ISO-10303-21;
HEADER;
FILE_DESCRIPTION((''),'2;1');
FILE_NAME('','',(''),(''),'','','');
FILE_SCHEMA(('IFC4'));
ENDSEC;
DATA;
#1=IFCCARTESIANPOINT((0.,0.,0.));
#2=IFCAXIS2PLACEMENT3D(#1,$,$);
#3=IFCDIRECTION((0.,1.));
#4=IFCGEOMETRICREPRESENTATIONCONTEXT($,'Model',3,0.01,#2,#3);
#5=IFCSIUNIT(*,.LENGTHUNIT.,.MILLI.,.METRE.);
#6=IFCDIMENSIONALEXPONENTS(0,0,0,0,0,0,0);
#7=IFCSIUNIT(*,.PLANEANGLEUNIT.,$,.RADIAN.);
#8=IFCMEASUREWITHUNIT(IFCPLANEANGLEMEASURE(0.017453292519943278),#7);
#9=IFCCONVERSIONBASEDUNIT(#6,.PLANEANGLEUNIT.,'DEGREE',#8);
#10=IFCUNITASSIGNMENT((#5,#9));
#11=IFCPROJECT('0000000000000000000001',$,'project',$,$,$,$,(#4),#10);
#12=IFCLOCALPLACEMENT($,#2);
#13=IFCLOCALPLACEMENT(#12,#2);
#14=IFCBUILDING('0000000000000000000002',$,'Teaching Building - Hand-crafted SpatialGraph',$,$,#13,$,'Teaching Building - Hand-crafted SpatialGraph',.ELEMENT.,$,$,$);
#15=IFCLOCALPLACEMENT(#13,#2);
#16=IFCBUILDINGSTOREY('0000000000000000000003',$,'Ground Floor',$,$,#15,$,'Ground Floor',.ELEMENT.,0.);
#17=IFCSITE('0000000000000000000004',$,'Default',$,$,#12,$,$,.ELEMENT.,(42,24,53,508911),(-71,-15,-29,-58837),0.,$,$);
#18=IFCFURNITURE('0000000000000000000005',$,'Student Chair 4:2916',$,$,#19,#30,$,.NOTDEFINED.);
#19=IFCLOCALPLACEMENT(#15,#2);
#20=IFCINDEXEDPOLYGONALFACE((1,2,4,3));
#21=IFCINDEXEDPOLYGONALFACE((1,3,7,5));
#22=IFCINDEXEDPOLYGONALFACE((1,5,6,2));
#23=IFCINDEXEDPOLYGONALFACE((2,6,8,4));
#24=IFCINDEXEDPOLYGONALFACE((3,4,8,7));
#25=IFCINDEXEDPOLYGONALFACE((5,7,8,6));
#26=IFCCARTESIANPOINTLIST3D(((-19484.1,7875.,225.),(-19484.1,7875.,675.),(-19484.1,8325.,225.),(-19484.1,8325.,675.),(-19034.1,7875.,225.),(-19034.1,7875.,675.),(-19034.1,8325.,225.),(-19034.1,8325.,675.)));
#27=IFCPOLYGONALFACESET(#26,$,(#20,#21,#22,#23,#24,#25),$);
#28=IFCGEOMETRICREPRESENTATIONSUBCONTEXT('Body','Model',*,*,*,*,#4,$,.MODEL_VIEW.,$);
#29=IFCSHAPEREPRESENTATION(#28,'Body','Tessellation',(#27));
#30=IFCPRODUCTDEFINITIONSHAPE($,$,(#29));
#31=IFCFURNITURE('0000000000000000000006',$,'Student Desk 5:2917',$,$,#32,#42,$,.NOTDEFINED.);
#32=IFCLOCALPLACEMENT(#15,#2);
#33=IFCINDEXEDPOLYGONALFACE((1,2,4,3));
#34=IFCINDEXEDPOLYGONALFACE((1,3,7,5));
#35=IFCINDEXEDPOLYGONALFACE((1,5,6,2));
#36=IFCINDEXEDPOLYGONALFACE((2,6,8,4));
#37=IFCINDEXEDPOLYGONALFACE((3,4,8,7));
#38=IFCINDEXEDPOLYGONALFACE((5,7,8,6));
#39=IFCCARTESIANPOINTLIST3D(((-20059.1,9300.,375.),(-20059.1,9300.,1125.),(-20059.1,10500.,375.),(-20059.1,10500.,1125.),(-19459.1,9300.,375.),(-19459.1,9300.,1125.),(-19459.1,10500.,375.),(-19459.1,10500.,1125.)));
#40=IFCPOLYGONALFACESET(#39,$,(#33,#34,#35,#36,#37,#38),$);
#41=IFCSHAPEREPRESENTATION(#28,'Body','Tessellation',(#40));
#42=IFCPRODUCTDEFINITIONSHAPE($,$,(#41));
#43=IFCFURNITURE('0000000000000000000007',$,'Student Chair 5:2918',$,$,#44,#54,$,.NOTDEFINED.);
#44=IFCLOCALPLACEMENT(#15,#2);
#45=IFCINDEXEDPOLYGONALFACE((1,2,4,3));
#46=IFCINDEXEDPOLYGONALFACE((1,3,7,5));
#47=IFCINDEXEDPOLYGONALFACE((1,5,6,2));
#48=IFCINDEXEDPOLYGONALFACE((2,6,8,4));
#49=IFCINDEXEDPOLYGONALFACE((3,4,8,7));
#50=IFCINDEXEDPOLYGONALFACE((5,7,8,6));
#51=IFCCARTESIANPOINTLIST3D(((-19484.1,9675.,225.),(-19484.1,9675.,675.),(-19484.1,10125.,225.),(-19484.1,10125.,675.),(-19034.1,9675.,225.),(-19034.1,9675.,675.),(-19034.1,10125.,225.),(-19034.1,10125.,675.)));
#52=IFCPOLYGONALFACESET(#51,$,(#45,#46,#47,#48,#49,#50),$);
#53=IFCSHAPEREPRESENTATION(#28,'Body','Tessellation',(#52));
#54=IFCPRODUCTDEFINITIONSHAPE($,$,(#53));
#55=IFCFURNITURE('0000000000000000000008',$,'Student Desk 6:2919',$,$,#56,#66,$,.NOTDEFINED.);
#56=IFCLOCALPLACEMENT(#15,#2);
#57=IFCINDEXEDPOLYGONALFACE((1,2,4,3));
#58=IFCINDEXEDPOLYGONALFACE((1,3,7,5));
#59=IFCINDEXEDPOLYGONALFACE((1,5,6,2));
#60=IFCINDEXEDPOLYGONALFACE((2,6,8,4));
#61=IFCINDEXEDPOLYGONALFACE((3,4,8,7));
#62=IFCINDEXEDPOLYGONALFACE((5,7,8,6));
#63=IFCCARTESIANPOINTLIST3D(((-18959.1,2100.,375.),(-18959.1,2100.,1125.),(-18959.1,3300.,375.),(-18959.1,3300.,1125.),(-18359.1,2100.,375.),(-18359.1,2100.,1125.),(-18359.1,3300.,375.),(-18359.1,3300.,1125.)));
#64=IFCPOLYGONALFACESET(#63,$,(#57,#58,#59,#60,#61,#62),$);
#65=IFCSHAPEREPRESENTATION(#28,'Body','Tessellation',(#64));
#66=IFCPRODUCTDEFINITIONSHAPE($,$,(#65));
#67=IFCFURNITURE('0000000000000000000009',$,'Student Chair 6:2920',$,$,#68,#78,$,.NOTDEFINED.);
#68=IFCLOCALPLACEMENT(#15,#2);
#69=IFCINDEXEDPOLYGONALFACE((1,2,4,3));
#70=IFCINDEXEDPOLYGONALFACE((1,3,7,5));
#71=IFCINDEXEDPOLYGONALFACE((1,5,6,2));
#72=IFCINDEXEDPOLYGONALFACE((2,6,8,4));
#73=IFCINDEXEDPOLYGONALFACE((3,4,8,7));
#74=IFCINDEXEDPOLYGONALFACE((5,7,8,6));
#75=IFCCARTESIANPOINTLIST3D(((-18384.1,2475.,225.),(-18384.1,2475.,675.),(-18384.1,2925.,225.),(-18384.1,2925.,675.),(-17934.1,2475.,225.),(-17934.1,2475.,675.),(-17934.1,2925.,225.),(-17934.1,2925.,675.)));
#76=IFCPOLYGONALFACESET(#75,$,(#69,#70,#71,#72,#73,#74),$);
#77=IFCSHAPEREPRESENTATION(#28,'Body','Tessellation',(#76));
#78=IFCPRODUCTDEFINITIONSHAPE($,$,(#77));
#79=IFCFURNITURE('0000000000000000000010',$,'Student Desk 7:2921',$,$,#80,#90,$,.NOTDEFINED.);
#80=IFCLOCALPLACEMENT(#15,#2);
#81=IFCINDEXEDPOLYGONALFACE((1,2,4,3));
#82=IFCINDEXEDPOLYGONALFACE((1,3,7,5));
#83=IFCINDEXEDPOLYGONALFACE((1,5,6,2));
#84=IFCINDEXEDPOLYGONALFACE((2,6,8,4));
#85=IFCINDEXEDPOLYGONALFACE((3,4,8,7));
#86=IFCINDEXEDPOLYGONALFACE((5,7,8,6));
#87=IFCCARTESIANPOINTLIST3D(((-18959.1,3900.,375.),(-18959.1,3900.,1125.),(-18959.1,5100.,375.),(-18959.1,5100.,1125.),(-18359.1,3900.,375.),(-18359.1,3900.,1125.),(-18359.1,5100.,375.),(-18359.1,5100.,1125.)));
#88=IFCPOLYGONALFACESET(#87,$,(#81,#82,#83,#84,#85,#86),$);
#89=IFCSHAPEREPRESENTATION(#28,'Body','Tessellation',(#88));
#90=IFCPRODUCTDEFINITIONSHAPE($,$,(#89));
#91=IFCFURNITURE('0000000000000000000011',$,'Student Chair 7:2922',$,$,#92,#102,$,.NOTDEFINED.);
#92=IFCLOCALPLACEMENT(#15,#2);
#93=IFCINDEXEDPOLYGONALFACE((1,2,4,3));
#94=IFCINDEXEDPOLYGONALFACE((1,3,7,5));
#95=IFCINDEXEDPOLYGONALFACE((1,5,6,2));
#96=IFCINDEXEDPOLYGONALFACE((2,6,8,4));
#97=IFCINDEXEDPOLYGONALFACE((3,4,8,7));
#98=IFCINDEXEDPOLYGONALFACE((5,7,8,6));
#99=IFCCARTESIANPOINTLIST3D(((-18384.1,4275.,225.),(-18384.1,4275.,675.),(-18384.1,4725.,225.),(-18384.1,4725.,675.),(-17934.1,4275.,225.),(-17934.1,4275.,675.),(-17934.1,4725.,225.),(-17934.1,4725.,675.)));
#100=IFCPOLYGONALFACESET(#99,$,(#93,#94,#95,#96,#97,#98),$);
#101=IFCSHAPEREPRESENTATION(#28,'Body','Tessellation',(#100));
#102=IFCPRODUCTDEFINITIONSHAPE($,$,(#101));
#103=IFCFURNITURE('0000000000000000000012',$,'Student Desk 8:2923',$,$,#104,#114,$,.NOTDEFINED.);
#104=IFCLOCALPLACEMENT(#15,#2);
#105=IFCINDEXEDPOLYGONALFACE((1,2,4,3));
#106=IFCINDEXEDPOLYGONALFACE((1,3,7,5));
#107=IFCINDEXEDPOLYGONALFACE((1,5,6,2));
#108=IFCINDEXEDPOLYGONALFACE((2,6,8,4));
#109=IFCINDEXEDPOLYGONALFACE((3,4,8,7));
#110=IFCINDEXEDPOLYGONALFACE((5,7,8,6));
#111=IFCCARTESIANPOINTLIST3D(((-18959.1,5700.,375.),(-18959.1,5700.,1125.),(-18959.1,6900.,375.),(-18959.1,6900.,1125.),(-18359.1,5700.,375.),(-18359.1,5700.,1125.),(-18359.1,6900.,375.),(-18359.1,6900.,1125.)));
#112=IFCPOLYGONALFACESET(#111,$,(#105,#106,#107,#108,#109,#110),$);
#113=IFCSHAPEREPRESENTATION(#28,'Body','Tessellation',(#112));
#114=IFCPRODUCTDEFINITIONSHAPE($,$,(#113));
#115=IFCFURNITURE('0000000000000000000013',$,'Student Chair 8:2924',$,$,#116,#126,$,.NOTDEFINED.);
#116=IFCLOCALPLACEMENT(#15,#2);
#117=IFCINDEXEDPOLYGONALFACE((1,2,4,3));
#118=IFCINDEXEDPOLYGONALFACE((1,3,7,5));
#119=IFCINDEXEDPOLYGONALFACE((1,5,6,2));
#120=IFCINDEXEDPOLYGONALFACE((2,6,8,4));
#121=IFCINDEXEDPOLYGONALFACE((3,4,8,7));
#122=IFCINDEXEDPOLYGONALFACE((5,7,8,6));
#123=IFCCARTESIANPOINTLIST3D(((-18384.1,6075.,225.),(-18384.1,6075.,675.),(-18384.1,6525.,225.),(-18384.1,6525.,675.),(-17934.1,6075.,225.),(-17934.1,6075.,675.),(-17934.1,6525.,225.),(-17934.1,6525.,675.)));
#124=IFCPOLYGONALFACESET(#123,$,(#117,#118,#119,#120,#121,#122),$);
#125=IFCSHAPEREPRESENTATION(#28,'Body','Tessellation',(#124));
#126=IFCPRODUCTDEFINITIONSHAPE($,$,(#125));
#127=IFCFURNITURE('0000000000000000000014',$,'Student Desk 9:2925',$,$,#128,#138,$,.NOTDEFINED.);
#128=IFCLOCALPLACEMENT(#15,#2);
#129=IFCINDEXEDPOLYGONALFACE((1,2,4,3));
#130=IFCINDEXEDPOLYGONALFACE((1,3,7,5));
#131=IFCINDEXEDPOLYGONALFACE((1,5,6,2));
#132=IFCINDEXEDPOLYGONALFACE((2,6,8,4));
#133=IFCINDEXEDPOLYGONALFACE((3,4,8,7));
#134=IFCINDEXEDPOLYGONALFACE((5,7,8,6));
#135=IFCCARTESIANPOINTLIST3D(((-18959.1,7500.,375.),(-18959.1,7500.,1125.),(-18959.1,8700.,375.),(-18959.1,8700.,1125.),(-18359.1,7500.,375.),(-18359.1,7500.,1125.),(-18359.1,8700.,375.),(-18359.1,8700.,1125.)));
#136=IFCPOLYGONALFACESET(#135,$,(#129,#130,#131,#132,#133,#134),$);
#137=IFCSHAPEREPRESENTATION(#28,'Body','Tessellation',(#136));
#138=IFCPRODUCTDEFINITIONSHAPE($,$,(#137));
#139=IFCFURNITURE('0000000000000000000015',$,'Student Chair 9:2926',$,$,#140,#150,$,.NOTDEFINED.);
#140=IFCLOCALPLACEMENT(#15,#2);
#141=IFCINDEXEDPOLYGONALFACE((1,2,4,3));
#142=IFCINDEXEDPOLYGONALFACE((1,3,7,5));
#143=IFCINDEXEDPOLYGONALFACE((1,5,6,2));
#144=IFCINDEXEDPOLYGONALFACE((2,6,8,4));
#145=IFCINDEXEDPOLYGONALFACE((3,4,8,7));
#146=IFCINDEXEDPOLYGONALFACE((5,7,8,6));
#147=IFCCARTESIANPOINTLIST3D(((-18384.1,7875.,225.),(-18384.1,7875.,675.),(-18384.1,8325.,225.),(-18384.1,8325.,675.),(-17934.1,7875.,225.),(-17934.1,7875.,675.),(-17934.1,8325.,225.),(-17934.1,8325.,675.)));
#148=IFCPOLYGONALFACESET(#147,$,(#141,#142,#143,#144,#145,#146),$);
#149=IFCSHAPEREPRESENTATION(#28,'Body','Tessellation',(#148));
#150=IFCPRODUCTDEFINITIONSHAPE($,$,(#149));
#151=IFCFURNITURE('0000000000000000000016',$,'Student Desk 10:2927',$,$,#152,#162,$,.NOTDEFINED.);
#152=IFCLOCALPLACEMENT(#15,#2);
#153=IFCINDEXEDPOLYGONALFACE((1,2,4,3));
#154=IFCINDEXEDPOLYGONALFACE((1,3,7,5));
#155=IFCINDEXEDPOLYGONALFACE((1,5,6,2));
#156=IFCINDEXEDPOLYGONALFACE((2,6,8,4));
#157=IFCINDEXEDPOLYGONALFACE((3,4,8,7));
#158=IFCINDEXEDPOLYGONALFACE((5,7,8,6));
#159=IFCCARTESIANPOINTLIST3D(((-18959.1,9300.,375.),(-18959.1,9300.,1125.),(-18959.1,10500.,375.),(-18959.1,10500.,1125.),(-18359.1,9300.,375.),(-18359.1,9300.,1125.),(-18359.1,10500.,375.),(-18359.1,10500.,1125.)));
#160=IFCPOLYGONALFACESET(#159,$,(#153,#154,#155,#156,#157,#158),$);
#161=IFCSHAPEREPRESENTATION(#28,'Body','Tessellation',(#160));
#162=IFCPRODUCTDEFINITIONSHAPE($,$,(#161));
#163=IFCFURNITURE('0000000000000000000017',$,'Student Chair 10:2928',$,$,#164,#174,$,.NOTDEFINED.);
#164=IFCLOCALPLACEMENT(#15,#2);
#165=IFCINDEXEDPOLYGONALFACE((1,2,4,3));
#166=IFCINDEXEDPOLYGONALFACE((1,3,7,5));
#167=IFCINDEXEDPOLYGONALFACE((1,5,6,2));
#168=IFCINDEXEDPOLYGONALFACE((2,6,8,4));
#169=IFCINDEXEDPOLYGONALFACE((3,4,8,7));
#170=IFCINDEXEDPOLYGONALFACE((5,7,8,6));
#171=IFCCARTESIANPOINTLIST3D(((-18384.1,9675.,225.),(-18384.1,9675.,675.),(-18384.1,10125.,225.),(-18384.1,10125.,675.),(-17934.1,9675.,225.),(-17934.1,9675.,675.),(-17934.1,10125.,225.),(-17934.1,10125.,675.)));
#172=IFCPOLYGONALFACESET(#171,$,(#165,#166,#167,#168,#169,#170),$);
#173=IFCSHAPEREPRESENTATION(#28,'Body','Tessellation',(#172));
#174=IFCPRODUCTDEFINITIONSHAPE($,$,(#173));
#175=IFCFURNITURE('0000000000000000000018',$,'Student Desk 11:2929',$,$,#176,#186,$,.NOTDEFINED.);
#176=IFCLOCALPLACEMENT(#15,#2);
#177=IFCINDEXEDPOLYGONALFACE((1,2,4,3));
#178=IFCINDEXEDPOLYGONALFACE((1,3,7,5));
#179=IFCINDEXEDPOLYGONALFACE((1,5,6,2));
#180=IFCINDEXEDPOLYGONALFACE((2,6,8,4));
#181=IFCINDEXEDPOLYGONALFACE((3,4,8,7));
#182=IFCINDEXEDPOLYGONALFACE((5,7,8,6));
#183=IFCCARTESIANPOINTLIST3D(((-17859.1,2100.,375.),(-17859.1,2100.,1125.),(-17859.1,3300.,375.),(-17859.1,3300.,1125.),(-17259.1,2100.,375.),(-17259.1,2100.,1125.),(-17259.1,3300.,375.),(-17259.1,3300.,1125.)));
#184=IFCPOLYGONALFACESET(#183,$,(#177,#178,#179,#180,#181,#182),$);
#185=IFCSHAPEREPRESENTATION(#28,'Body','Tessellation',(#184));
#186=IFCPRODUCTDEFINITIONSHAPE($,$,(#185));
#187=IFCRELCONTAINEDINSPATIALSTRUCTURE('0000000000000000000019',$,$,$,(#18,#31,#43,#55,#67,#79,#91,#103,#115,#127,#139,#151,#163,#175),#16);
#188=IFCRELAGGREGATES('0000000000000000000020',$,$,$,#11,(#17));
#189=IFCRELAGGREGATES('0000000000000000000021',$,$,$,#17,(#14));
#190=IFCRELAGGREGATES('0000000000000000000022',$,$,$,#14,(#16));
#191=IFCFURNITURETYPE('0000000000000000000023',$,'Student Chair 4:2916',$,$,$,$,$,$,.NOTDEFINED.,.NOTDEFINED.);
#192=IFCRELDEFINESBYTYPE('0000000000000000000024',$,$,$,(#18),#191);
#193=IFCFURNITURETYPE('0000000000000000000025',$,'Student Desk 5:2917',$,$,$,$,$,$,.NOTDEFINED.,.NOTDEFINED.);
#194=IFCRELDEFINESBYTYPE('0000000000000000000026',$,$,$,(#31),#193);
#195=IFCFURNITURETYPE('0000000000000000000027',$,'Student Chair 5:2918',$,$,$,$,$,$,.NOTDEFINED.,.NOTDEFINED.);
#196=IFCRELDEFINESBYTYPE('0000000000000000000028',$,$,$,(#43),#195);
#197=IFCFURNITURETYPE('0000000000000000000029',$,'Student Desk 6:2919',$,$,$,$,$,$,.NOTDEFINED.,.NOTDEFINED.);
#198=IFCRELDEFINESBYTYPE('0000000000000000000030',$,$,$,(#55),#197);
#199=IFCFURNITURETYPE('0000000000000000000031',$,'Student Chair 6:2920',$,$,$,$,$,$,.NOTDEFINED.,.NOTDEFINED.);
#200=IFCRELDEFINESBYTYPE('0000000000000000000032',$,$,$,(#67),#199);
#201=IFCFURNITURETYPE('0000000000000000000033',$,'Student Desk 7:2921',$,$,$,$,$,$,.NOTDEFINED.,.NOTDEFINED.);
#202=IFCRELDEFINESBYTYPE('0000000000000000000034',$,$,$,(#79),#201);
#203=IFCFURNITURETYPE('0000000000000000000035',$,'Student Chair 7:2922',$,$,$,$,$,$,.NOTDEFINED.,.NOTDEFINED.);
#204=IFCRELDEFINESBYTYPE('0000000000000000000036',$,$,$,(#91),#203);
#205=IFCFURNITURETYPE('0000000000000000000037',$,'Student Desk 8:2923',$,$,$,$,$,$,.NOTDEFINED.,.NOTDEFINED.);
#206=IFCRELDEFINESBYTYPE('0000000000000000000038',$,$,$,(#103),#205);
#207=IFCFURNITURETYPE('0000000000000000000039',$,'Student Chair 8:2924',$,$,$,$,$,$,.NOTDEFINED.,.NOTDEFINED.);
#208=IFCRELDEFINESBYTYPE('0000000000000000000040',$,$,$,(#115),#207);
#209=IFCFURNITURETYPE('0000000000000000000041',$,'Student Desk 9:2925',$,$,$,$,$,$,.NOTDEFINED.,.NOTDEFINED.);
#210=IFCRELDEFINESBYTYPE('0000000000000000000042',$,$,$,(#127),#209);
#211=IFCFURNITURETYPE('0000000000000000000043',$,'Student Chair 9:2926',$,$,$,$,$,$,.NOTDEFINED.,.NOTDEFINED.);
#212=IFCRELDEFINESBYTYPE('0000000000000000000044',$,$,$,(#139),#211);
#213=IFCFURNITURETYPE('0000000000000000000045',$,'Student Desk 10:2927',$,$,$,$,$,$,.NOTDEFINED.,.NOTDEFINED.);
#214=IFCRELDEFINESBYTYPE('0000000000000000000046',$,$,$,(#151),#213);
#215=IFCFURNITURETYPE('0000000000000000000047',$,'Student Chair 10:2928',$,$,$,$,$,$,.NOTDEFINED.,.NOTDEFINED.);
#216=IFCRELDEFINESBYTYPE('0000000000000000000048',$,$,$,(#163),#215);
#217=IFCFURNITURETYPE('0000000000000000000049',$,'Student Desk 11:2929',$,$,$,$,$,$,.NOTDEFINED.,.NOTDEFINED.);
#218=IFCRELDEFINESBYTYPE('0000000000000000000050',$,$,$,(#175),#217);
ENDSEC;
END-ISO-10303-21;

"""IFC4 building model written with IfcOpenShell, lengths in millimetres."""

from ifc_helpers import new_model, entity, si_unit, converted_unit, direction, frame, frame_2d, origin, origin_2d_with_axis, place, context, subcontext, project, spatial, rectangle, extrude, type_object, element, save


model = new_model("IFC4")

# Units and contexts
model_context = context("Model", 3, precision=0.01, world=origin(), true_north=direction((0.0, 1.0)))
body_context = subcontext(model_context, "Body", "Model", "MODEL_VIEW")
ifc_project = project(units=[si_unit("LENGTHUNIT", "METRE", prefix="MILLI"), converted_unit("PLANEANGLEUNIT", "DEGREE", entity("IfcPlaneAngleMeasure", 0.017453292519943278), si_unit("PLANEANGLEUNIT", "RADIAN"), dimensions=[0, 0, 0, 0, 0, 0, 0])], contexts=[model_context])

# Site, building, storey
site_placement = place(None, origin())
site = spatial("IfcSite", under=ifc_project, at=site_placement, Name="Default", CompositionType="ELEMENT", RefLatitude=(42, 24, 53, 508911), RefLongitude=(-71, -15, -29, -58837), RefElevation=0.0)
building_placement = place(site_placement, origin())
building = spatial("IfcBuilding", under=site, at=building_placement, Name="Teaching Building - Hand-crafted SpatialGraph", LongName="Teaching Building - Hand-crafted SpatialGraph", CompositionType="ELEMENT")
storey_placement = place(building_placement, origin())
storey = spatial("IfcBuildingStorey", under=building, at=storey_placement, Name="Ground Floor", LongName="Ground Floor", CompositionType="ELEMENT", Elevation=0.0)

# Furniture
furniture_type_1 = type_object("IfcFurnitureType", Name="Student Chair 4:2916", PredefinedType="NOTDEFINED")
furniture_1_placement = place(storey_placement, origin())
element("IfcFurniture", 1, at=furniture_1_placement, inside=storey, type_object=furniture_type_1, Name="Student Chair 4:2916", PredefinedType="NOTDEFINED", context=body_context, shape_type="SweptSolid", body=[
    extrude(rectangle(XDim=450.0, YDim=450.0, at=origin_2d_with_axis()), frame((-19259.1, 8100.0, 225.0)), (0.0, 0.0, 1.0), 450.0),
])
furniture_type_2 = type_object("IfcFurnitureType", Name="Student Desk 5:2917", PredefinedType="NOTDEFINED")
furniture_2_placement = place(storey_placement, origin())
element("IfcFurniture", 2, at=furniture_2_placement, inside=storey, type_object=furniture_type_2, Name="Student Desk 5:2917", PredefinedType="NOTDEFINED", context=body_context, shape_type="SweptSolid", body=[
    extrude(rectangle(XDim=1200.0, YDim=600.0, at=frame_2d((0.0, 0.0), x_axis=(1.0, 0.0))), frame((-19759.1, 9900.0, 375.0), z_axis=(0.0, 0.0, 1.0), x_axis=(0.0, 1.0, 0.0)), (0.0, 0.0, 1.0), 750.0),
])
furniture_type_3 = type_object("IfcFurnitureType", Name="Student Chair 5:2918", PredefinedType="NOTDEFINED")
furniture_3_placement = place(storey_placement, origin())
element("IfcFurniture", 3, at=furniture_3_placement, inside=storey, type_object=furniture_type_3, Name="Student Chair 5:2918", PredefinedType="NOTDEFINED", context=body_context, shape_type="SweptSolid", body=[
    extrude(rectangle(XDim=450.0, YDim=450.0, at=frame_2d((0.0, 0.0), x_axis=(1.0, 0.0))), frame((-19259.1, 9900.0, 225.0)), (0.0, 0.0, 1.0), 450.0),
])
furniture_type_4 = type_object("IfcFurnitureType", Name="Student Desk 6:2919", PredefinedType="NOTDEFINED")
furniture_4_placement = place(storey_placement, origin())
element("IfcFurniture", 4, at=furniture_4_placement, inside=storey, type_object=furniture_type_4, Name="Student Desk 6:2919", PredefinedType="NOTDEFINED", context=body_context, shape_type="SweptSolid", body=[
    extrude(rectangle(XDim=1200.0, YDim=600.0, at=frame_2d((0.0, 0.0), x_axis=(1.0, 0.0))), frame((-18659.1, 2700.0, 375.0), z_axis=(0.0, 0.0, 1.0), x_axis=(0.0, 1.0, 0.0)), (0.0, 0.0, 1.0), 750.0),
])
furniture_type_5 = type_object("IfcFurnitureType", Name="Student Chair 6:2920", PredefinedType="NOTDEFINED")
furniture_5_placement = place(storey_placement, origin())
element("IfcFurniture", 5, at=furniture_5_placement, inside=storey, type_object=furniture_type_5, Name="Student Chair 6:2920", PredefinedType="NOTDEFINED", context=body_context, shape_type="SweptSolid", body=[
    extrude(rectangle(XDim=450.0, YDim=450.0, at=origin_2d_with_axis()), frame((-18159.1, 2700.0, 225.0)), (0.0, 0.0, 1.0), 450.0),
])
furniture_type_6 = type_object("IfcFurnitureType", Name="Student Desk 7:2921", PredefinedType="NOTDEFINED")
furniture_6_placement = place(storey_placement, origin())
element("IfcFurniture", 6, at=furniture_6_placement, inside=storey, type_object=furniture_type_6, Name="Student Desk 7:2921", PredefinedType="NOTDEFINED", context=body_context, shape_type="SweptSolid", body=[
    extrude(rectangle(XDim=1200.0, YDim=600.0, at=frame_2d((0.0, 0.0), x_axis=(1.0, 0.0))), frame((-18659.1, 4500.0, 375.0), z_axis=(0.0, 0.0, 1.0), x_axis=(0.0, 1.0, 0.0)), (0.0, 0.0, 1.0), 750.0),
])
furniture_type_7 = type_object("IfcFurnitureType", Name="Student Chair 7:2922", PredefinedType="NOTDEFINED")
furniture_7_placement = place(storey_placement, origin())
element("IfcFurniture", 7, at=furniture_7_placement, inside=storey, type_object=furniture_type_7, Name="Student Chair 7:2922", PredefinedType="NOTDEFINED", context=body_context, shape_type="SweptSolid", body=[
    extrude(rectangle(XDim=450.0, YDim=450.0, at=origin_2d_with_axis()), frame((-18159.1, 4500.0, 225.0)), (0.0, 0.0, 1.0), 450.0),
])
furniture_type_8 = type_object("IfcFurnitureType", Name="Student Desk 8:2923", PredefinedType="NOTDEFINED")
furniture_8_placement = place(storey_placement, origin())
element("IfcFurniture", 8, at=furniture_8_placement, inside=storey, type_object=furniture_type_8, Name="Student Desk 8:2923", PredefinedType="NOTDEFINED", context=body_context, shape_type="SweptSolid", body=[
    extrude(rectangle(XDim=1200.0, YDim=600.0, at=frame_2d((0.0, 0.0), x_axis=(1.0, 0.0))), frame((-18659.1, 6300.0, 375.0), z_axis=(0.0, 0.0, 1.0), x_axis=(0.0, 1.0, 0.0)), (0.0, 0.0, 1.0), 750.0),
])
furniture_type_9 = type_object("IfcFurnitureType", Name="Student Chair 8:2924", PredefinedType="NOTDEFINED")
furniture_9_placement = place(storey_placement, origin())
element("IfcFurniture", 9, at=furniture_9_placement, inside=storey, type_object=furniture_type_9, Name="Student Chair 8:2924", PredefinedType="NOTDEFINED", context=body_context, shape_type="SweptSolid", body=[
    extrude(rectangle(XDim=450.0, YDim=450.0, at=origin_2d_with_axis()), frame((-18159.1, 6300.0, 225.0)), (0.0, 0.0, 1.0), 450.0),
])
furniture_type_10 = type_object("IfcFurnitureType", Name="Student Desk 9:2925", PredefinedType="NOTDEFINED")
furniture_10_placement = place(storey_placement, origin())
element("IfcFurniture", 10, at=furniture_10_placement, inside=storey, type_object=furniture_type_10, Name="Student Desk 9:2925", PredefinedType="NOTDEFINED", context=body_context, shape_type="SweptSolid", body=[
    extrude(rectangle(XDim=1200.0, YDim=600.0, at=frame_2d((0.0, 0.0), x_axis=(1.0, 0.0))), frame((-18659.1, 8100.0, 375.0), z_axis=(0.0, 0.0, 1.0), x_axis=(0.0, 1.0, 0.0)), (0.0, 0.0, 1.0), 750.0),
])
furniture_type_11 = type_object("IfcFurnitureType", Name="Student Chair 9:2926", PredefinedType="NOTDEFINED")
furniture_11_placement = place(storey_placement, origin())
element("IfcFurniture", 11, at=furniture_11_placement, inside=storey, type_object=furniture_type_11, Name="Student Chair 9:2926", PredefinedType="NOTDEFINED", context=body_context, shape_type="SweptSolid", body=[
    extrude(rectangle(XDim=450.0, YDim=450.0, at=origin_2d_with_axis()), frame((-18159.1, 8100.0, 225.0)), (0.0, 0.0, 1.0), 450.0),
])
furniture_type_12 = type_object("IfcFurnitureType", Name="Student Desk 10:2927", PredefinedType="NOTDEFINED")
furniture_12_placement = place(storey_placement, origin())
element("IfcFurniture", 12, at=furniture_12_placement, inside=storey, type_object=furniture_type_12, Name="Student Desk 10:2927", PredefinedType="NOTDEFINED", context=body_context, shape_type="SweptSolid", body=[
    extrude(rectangle(XDim=1200.0, YDim=600.0, at=frame_2d((0.0, 0.0), x_axis=(1.0, 0.0))), frame((-18659.1, 9900.0, 375.0), z_axis=(0.0, 0.0, 1.0), x_axis=(0.0, 1.0, 0.0)), (0.0, 0.0, 1.0), 750.0),
])
furniture_type_13 = type_object("IfcFurnitureType", Name="Student Chair 10:2928", PredefinedType="NOTDEFINED")
furniture_13_placement = place(storey_placement, origin())
element("IfcFurniture", 13, at=furniture_13_placement, inside=storey, type_object=furniture_type_13, Name="Student Chair 10:2928", PredefinedType="NOTDEFINED", context=body_context, shape_type="SweptSolid", body=[
    extrude(rectangle(XDim=450.0, YDim=450.0, at=frame_2d((0.0, 0.0), x_axis=(1.0, 0.0))), frame((-18159.1, 9900.0, 225.0)), (0.0, 0.0, 1.0), 450.0),
])
furniture_type_14 = type_object("IfcFurnitureType", Name="Student Desk 11:2929", PredefinedType="NOTDEFINED")
furniture_14_placement = place(storey_placement, origin())
element("IfcFurniture", 14, at=furniture_14_placement, inside=storey, type_object=furniture_type_14, Name="Student Desk 11:2929", PredefinedType="NOTDEFINED", context=body_context, shape_type="SweptSolid", body=[
    extrude(rectangle(XDim=1200.0, YDim=600.0, at=origin_2d_with_axis()), frame((-17559.1, 2700.0, 375.0), z_axis=(0.0, 0.0, 1.0), x_axis=(0.0, 1.0, 0.0)), (0.0, 0.0, 1.0), 750.0),
])

save(model, "model.ifc")
